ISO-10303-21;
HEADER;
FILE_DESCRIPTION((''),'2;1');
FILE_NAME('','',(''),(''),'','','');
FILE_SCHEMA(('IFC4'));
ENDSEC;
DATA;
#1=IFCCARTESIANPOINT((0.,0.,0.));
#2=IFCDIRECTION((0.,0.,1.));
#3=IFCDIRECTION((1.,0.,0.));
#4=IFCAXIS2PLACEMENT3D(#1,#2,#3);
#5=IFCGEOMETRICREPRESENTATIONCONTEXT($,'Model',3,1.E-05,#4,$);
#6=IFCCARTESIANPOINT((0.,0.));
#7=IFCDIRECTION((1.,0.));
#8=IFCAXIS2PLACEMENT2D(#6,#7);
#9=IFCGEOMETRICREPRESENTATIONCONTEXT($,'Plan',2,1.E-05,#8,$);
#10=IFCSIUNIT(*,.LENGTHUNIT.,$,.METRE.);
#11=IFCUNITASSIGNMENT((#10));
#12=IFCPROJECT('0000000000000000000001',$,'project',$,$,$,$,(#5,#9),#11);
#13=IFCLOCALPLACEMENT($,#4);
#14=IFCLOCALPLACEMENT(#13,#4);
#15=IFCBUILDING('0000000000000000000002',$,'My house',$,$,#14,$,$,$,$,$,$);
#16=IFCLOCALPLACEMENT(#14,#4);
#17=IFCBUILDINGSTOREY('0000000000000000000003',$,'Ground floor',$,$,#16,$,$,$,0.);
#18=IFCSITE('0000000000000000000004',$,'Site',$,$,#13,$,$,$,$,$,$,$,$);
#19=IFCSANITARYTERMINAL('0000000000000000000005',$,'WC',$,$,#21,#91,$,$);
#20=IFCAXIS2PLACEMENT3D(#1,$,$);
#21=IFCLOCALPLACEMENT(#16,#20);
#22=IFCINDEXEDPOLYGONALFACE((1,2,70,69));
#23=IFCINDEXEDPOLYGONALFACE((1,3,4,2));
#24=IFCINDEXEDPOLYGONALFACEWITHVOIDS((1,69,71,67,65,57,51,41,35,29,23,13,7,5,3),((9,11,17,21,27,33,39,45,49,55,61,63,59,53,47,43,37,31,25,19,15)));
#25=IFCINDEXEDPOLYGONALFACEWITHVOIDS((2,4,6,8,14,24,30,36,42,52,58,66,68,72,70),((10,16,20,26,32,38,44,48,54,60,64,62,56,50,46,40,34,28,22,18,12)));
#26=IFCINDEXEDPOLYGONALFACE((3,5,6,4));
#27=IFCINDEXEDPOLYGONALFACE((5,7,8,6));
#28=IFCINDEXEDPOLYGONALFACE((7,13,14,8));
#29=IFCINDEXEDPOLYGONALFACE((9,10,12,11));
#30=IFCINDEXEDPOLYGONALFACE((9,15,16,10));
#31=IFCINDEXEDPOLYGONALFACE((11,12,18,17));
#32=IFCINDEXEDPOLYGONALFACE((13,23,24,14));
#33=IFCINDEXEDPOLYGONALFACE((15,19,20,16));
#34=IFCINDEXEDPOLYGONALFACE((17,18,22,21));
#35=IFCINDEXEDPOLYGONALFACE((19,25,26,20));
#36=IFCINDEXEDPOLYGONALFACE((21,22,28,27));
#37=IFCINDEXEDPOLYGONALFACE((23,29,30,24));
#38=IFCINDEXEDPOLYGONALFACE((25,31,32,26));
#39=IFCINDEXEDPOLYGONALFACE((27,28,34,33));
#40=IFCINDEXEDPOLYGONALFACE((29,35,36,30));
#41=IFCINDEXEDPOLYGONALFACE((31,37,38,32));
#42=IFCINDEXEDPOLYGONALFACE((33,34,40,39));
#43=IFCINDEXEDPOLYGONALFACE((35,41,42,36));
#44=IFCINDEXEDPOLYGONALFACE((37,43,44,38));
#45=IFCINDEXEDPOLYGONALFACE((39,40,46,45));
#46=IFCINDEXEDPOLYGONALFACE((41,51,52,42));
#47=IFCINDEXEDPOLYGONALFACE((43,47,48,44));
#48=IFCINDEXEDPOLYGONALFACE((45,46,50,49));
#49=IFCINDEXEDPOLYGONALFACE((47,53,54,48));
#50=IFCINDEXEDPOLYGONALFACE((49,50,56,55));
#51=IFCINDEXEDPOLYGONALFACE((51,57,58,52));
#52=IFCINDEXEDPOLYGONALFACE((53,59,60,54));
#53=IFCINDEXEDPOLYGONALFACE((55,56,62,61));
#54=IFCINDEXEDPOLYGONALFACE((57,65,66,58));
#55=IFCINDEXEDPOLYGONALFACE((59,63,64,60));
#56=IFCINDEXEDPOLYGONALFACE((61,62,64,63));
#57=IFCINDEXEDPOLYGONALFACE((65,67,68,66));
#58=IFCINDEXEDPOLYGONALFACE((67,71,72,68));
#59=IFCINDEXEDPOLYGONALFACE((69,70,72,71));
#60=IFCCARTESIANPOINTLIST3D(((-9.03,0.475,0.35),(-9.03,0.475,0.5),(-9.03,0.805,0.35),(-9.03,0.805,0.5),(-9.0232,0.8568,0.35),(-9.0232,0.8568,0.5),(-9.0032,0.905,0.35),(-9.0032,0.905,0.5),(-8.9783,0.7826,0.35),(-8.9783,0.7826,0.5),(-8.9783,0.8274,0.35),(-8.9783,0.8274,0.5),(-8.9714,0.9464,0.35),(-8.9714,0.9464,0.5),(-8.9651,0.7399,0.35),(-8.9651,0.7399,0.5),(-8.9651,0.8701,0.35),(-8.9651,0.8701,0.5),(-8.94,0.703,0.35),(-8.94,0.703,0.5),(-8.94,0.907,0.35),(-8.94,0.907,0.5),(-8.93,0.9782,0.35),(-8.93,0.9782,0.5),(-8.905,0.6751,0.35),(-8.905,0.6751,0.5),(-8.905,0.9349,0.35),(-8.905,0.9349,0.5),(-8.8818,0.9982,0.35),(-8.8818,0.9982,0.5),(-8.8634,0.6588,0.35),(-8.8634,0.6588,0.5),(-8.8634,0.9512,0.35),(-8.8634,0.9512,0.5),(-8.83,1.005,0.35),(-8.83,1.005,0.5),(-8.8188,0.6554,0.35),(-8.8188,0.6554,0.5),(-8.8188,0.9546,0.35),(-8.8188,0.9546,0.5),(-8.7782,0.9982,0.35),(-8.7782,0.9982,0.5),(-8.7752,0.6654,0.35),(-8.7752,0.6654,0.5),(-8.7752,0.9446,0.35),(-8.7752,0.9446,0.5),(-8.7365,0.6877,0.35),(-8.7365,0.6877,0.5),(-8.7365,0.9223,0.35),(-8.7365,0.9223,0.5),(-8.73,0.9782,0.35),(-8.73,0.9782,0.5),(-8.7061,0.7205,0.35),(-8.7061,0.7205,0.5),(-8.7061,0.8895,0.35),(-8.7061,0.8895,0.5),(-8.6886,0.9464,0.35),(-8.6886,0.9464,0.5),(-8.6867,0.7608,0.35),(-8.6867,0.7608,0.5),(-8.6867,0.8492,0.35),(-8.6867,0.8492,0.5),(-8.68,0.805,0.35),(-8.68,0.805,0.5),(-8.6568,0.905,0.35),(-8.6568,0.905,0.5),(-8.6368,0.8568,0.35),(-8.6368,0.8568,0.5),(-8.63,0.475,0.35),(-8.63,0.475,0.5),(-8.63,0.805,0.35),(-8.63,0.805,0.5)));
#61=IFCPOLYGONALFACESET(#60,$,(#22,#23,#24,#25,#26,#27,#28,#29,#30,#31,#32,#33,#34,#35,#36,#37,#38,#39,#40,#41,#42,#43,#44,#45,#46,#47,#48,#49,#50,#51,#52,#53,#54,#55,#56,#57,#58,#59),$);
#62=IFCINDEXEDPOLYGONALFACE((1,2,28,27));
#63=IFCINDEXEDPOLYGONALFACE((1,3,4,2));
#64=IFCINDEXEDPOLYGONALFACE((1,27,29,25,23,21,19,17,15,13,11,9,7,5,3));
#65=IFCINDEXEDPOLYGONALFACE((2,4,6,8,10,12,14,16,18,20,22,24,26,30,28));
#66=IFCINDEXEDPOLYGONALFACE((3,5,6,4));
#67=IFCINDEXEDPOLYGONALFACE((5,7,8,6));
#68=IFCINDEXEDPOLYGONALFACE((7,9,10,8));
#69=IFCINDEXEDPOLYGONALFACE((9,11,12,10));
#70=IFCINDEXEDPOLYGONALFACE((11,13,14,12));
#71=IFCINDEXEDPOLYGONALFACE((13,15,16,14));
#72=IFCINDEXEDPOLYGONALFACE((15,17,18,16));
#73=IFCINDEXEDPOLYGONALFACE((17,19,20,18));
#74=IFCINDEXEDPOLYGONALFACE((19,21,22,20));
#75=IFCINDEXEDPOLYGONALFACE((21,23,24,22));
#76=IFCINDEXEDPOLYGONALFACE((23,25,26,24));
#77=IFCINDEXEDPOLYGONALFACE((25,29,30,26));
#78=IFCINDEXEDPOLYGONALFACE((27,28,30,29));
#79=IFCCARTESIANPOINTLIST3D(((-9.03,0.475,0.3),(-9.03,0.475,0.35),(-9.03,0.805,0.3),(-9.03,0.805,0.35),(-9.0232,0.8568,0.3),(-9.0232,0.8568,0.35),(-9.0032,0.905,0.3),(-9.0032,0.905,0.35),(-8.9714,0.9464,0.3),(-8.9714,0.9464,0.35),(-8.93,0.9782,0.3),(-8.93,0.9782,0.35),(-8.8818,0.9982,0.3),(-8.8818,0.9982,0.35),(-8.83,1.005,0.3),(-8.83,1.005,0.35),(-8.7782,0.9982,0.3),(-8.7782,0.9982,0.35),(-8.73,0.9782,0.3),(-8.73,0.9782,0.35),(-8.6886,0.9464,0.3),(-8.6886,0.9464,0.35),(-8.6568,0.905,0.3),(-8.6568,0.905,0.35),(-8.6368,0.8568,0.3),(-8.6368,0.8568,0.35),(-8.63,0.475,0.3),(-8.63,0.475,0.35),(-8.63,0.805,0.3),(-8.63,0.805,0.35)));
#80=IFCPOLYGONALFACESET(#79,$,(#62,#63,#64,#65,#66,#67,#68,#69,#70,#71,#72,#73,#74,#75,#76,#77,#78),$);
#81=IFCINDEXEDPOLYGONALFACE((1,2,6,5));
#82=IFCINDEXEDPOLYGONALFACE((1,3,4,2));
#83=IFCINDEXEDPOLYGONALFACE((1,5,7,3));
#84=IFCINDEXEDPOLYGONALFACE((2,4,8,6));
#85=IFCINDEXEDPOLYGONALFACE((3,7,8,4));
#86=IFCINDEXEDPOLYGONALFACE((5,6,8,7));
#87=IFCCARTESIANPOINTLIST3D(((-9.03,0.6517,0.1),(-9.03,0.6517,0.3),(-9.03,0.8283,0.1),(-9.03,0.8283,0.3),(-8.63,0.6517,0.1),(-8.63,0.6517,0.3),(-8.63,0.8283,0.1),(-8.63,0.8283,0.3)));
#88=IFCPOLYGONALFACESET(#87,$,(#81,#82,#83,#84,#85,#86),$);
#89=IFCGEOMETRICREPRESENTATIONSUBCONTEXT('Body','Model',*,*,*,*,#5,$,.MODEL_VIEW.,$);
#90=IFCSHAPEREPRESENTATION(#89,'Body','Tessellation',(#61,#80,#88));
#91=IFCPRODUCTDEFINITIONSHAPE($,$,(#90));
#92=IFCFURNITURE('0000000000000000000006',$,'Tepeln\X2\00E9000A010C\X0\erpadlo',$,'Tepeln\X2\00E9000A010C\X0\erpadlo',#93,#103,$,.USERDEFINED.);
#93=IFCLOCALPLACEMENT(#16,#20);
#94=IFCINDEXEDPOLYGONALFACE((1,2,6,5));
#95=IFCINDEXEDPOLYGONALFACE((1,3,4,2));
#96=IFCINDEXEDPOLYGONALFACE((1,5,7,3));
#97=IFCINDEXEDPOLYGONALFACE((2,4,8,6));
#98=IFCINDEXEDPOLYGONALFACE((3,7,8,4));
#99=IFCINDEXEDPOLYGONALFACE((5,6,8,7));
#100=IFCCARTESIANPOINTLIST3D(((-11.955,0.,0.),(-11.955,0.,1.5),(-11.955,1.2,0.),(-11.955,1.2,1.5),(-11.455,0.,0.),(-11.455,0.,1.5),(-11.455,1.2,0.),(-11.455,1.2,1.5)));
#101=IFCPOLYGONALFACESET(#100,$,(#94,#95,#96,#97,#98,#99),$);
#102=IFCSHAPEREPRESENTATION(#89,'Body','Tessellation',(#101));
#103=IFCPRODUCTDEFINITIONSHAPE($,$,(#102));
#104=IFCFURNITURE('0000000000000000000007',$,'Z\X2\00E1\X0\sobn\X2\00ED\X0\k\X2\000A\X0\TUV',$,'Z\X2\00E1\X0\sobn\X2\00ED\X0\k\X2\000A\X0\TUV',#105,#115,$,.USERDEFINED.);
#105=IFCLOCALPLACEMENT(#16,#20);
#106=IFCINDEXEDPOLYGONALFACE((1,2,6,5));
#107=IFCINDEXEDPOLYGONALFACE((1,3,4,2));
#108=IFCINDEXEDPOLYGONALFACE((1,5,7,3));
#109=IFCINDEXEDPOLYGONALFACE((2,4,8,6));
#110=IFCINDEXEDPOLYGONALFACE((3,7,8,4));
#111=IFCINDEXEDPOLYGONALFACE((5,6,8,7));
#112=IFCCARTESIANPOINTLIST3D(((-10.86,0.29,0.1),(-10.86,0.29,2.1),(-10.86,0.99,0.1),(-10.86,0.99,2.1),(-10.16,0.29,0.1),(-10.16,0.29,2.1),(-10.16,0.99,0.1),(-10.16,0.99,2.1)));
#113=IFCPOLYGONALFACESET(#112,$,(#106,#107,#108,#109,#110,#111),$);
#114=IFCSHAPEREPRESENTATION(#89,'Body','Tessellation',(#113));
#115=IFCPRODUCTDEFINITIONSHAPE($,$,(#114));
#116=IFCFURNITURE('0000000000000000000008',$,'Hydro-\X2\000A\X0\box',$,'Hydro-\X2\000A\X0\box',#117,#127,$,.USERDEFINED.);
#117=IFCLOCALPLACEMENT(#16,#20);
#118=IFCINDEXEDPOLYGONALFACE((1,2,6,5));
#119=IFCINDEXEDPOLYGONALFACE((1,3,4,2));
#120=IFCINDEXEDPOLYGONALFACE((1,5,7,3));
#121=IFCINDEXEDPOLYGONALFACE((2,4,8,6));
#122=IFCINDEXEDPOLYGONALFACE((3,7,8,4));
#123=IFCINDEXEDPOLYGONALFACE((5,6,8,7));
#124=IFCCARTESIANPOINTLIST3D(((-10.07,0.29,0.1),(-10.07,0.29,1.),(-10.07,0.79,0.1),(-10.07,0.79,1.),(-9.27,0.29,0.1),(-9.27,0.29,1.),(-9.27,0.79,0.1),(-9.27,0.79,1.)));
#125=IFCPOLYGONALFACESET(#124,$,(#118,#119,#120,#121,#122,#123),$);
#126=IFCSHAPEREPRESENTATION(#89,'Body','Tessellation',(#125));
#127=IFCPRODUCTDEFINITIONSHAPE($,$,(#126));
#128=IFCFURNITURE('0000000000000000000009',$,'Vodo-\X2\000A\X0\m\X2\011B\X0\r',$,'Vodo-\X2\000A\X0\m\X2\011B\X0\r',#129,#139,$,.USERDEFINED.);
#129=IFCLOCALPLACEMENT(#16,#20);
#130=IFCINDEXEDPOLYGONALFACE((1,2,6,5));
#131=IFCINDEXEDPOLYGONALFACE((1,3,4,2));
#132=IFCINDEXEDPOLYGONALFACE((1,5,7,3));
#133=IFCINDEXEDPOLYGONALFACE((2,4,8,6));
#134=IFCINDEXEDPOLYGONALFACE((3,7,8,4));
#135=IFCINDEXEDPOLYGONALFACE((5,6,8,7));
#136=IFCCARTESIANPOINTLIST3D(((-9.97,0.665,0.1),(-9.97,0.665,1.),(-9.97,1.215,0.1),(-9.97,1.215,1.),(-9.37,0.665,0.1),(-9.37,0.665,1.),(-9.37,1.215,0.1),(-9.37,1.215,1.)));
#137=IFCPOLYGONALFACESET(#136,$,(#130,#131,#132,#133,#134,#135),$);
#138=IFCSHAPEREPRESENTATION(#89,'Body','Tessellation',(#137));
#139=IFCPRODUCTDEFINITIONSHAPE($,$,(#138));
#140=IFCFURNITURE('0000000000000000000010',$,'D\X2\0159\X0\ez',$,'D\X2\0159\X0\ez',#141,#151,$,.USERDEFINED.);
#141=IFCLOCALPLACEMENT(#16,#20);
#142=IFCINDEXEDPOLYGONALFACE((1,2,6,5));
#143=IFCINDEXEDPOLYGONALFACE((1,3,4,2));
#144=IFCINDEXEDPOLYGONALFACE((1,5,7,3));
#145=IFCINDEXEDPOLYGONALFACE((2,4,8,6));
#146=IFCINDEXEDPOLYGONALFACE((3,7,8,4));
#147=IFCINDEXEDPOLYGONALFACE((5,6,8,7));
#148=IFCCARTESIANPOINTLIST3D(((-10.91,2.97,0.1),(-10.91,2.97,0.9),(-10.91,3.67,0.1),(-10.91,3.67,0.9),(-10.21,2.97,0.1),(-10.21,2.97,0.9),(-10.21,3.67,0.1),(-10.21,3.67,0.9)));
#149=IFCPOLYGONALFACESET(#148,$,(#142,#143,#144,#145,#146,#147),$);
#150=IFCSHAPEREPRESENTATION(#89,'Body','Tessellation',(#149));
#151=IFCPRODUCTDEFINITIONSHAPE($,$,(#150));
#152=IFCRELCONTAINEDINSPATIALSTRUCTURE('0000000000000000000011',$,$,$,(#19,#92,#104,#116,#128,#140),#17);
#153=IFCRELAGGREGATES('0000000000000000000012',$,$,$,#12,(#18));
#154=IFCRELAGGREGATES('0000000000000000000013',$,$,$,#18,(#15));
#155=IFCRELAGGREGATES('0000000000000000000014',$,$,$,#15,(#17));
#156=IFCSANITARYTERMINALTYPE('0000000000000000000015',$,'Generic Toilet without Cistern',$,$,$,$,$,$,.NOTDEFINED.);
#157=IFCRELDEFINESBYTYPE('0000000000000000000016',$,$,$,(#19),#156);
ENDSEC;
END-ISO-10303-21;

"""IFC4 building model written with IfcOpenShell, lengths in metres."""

from ifc_helpers import new_model, entity, si_unit, frame, frame_2d, origin_with_axes, origin_2d_with_axis, place, context, subcontext, project, spatial, line, arc, indexed_curve, circle_curve, outline, extrude, shape, source, transform, mapped, type_object, type_shapes, element, save


model = new_model("IFC4")

# Units and contexts
model_context = context("Model", 3, precision=1e-05, world=origin_with_axes())
plan_context = context("Plan", 2, precision=1e-05, world=origin_2d_with_axis())
body_context_1 = subcontext(model_context, "Body", "Model", "MODEL_VIEW")
body_context_2 = subcontext(plan_context, "Body", "Plan", "PLAN_VIEW")
ifc_project = project(units=[si_unit("LENGTHUNIT", "METRE")], contexts=[model_context, plan_context])

# Site, building, storey
site_placement = place(None, origin_with_axes())
site = spatial("IfcSite", under=ifc_project, at=site_placement, Name="Site")
building_placement = place(site_placement, origin_with_axes())
building = spatial("IfcBuilding", under=site, at=building_placement, Name="My house")
storey_placement = place(building_placement, origin_with_axes())
storey = spatial("IfcBuildingStorey", under=building, at=storey_placement, Name="Ground floor", Elevation=0.0)

# Sanitary terminal
sanitary_terminal_type_1 = type_object("IfcSanitaryTerminalType", Name="Generic Toilet without Cistern", PredefinedType="NOTDEFINED")
shared_shape_1 = source(origin_with_axes(), body_context_1, "Body", "SweptSolid", [
    extrude(outline(indexed_curve([(-0.2, 0.0), (0.2, 0.0), (0.2, -0.33), (0.1414, -0.4714), (0.0, -0.53), (-0.1414, -0.4714), (-0.2, -0.33)], segments=[line(1, 2), line(2, 3), arc(3, 4, 5), arc(5, 6, 7), line(7, 1)]), holes=[circle_curve(frame_2d((0.0, -0.33)), 0.15)]), frame((0.0, 0.0, 0.25), z_axis=(0.0, 0.0, 1.0), x_axis=(1.0, 0.0, 0.0)), (0.0, 0.0, 1.0), 0.15),
    extrude(outline(indexed_curve([(-0.2, 0.0), (0.2, 0.0), (0.2, -0.33), (0.1414, -0.4714), (0.0, -0.53), (-0.1414, -0.4714), (-0.2, -0.33)], segments=[line(1, 2), line(2, 3), arc(3, 4, 5), arc(5, 6, 7), line(7, 1)])), frame((0.0, 0.0, 0.2), z_axis=(0.0, 0.0, 1.0), x_axis=(1.0, 0.0, 0.0)), (0.0, 0.0, 1.0), 0.05),
    extrude(outline(indexed_curve([(-0.2, -0.1767), (0.2, -0.1767), (0.2, -0.3533), (-0.2, -0.3533)], segments=[line(1, 2, 3, 4, 1)])), origin_with_axes(), (0.0, 0.0, 1.0), 0.2),
])
shared_shape_2 = source(origin_with_axes(), body_context_1, "Body", "MappedRepresentation", [
    mapped(shared_shape_1, transform((0.0, 0.0, 0.0), x_axis=(1.0, 0.0, 0.0), y_axis=(0.0, 1.0, 0.0), z_axis=(0.0, 0.0, 1.0), scale=1.0)),
])
shared_shape_3 = source(origin_with_axes(), body_context_2, "Body", "Curve2D", [
    entity("IfcIndexedPolyCurve", entity("IfcCartesianPointList2D", [[-0.12, 0.0], [0.12, 0.0]])),
    entity("IfcIndexedPolyCurve", entity("IfcCartesianPointList2D", [[0.12, 0.0], [0.2, -0.159]])),
    entity("IfcTrimmedCurve", entity("IfcEllipse", entity("IfcAxis2Placement2D", entity("IfcCartesianPoint", [0.0, -0.159]), entity("IfcDirection", [1.0, 0.0])), 0.2, 0.371), [entity("IfcCartesianPoint", [-0.2, -0.159])], [entity("IfcCartesianPoint", [0.2, -0.159])], True, "CARTESIAN"),
    entity("IfcIndexedPolyCurve", entity("IfcCartesianPointList2D", [[-0.12, 0.0], [-0.2, -0.159]])),
    entity("IfcEllipse", entity("IfcAxis2Placement2D", entity("IfcCartesianPoint", [0.0, -0.2968]), entity("IfcDirection", [1.0, 0.0])), 0.15, 0.1855),
    entity("IfcIndexedPolyCurve", entity("IfcCartesianPointList2D", [[-0.025, -0.2968], [-0.025, -0.2703], [0.025, -0.2703], [0.025, -0.2968]])),
    entity("IfcTrimmedCurve", entity("IfcEllipse", entity("IfcAxis2Placement2D", entity("IfcCartesianPoint", [0.0, -0.2968]), entity("IfcDirection", [1.0, 0.0])), 0.025, 0.0265), [entity("IfcCartesianPoint", [-0.025, -0.2968])], [entity("IfcCartesianPoint", [0.025, -0.2968])], True, "CARTESIAN"),
])
type_shapes(sanitary_terminal_type_1, [shared_shape_1, shared_shape_3])
shared_shape_4 = source(origin_with_axes(), body_context_2, "Body", "MappedRepresentation", [
    mapped(shared_shape_3, transform((0.0, 0.0, 0.0), x_axis=(1.0, 0.0, 0.0), y_axis=(0.0, 1.0, 0.0), z_axis=(0.0, 0.0, 1.0), scale=1.0)),
])
sanitary_terminal_1_placement = place(storey_placement, frame((-8.83, 0.475, 0.1), z_axis=(0.0, 0.0, 1.0), x_axis=(-1.0, 0.0, 0.0)))
element("IfcSanitaryTerminal", 1, at=sanitary_terminal_1_placement, inside=storey, type_object=sanitary_terminal_type_1, Name="WC", shapes=[
    shape(body_context_1, "Body", "MappedRepresentation", [mapped(shared_shape_2, transform((0.0, 0.0, 0.0), x_axis=(-1.0, 0.0, 0.0), y_axis=(0.0, 1.0, 0.0), z_axis=(0.0, 0.0, 1.0), scale=1.0))]),
    shape(body_context_2, "Body", "MappedRepresentation", [mapped(shared_shape_4, transform((0.0, 0.0, 0.0), x_axis=(-1.0, 0.0, 0.0), y_axis=(0.0, 1.0, 0.0), z_axis=(0.0, 0.0, 1.0), scale=1.0))]),
])

# Furniture
shared_shape_5 = source(origin_with_axes(), body_context_1, "Body", "SweptSolid", [
    extrude(outline(indexed_curve([(-0.6, -0.25), (0.6, -0.25), (0.6, 0.25), (-0.6, 0.25)])), None, (0.0, 0.0, 1.0), 1.5),
])
shared_shape_6 = source(origin_with_axes(), body_context_2, "Body", "Curve2D", [
    entity("IfcIndexedPolyCurve", entity("IfcCartesianPointList2D", [[-0.6, -0.25], [0.6, -0.25], [0.6, 0.25], [-0.6, 0.25], [-0.6, -0.25]]), None, False),
])
furniture_1_placement = place(storey_placement, frame((-11.705, 0.6, 0.0), z_axis=(0.0, 0.0, 1.0), x_axis=(0.0, 1.0, 0.0)))
element("IfcFurniture", 2, at=furniture_1_placement, inside=storey, Name="Tepelné\nČerpadlo", ObjectType="Tepelné\nČerpadlo", PredefinedType="USERDEFINED", shapes=[
    shape(body_context_1, "Body", "MappedRepresentation", [mapped(shared_shape_5, transform((0.0, 0.0, 0.0), x_axis=(-1.0, 0.0, 0.0), y_axis=(0.0, 1.0, 0.0), z_axis=(0.0, 0.0, 1.0), scale=1.0))]),
    shape(body_context_2, "Body", "MappedRepresentation", [mapped(shared_shape_6, transform((0.0, 0.0, 0.0), x_axis=(-1.0, 0.0, 0.0), y_axis=(0.0, 1.0, 0.0), z_axis=(0.0, 0.0, 1.0), scale=1.0))]),
])
shared_shape_7 = source(origin_with_axes(), body_context_1, "Body", "SweptSolid", [
    extrude(outline(indexed_curve([(-0.35, -0.35), (0.35, -0.35), (0.35, 0.35), (-0.35, 0.35)])), None, (0.0, 0.0, 1.0), 2.0),
])
shared_shape_8 = source(origin_with_axes(), body_context_2, "Body", "Curve2D", [
    entity("IfcIndexedPolyCurve", entity("IfcCartesianPointList2D", [[-0.35, -0.35], [0.35, -0.35], [0.35, 0.35], [-0.35, 0.35], [-0.35, -0.35]]), None, False),
])
furniture_2_placement = place(storey_placement, frame((-10.51, 0.64, 0.1), z_axis=(0.0, 0.0, 1.0), x_axis=(1.0, 0.0, 0.0)))
element("IfcFurniture", 3, at=furniture_2_placement, inside=storey, Name="Zásobník\nTUV", ObjectType="Zásobník\nTUV", PredefinedType="USERDEFINED", shapes=[
    shape(body_context_1, "Body", "MappedRepresentation", [mapped(shared_shape_7, transform((0.0, 0.0, 0.0), x_axis=(-1.0, 0.0, 0.0), y_axis=(0.0, 1.0, 0.0), z_axis=(0.0, 0.0, 1.0), scale=1.0))]),
    shape(body_context_2, "Body", "MappedRepresentation", [mapped(shared_shape_8, transform((0.0, 0.0, 0.0), x_axis=(-1.0, 0.0, 0.0), y_axis=(0.0, 1.0, 0.0), z_axis=(0.0, 0.0, 1.0), scale=1.0))]),
])
shared_shape_9 = source(origin_with_axes(), body_context_1, "Body", "SweptSolid", [
    extrude(outline(indexed_curve([(-0.4, -0.25), (0.4, -0.25), (0.4, 0.25), (-0.4, 0.25)])), None, (0.0, 0.0, 1.0), 0.9),
])
shared_shape_10 = source(origin_with_axes(), body_context_2, "Body", "Curve2D", [
    entity("IfcIndexedPolyCurve", entity("IfcCartesianPointList2D", [[-0.4, -0.25], [0.4, -0.25], [0.4, 0.25], [-0.4, 0.25], [-0.4, -0.25]]), None, False),
])
furniture_3_placement = place(storey_placement, frame((-9.67, 0.54, 0.1), z_axis=(0.0, 0.0, 1.0), x_axis=(1.0, 0.0, 0.0)))
element("IfcFurniture", 4, at=furniture_3_placement, inside=storey, Name="Hydro-\nbox", ObjectType="Hydro-\nbox", PredefinedType="USERDEFINED", shapes=[
    shape(body_context_1, "Body", "MappedRepresentation", [mapped(shared_shape_9, transform((0.0, 0.0, 0.0), x_axis=(-1.0, 0.0, 0.0), y_axis=(0.0, 1.0, 0.0), z_axis=(0.0, 0.0, 1.0), scale=1.0))]),
    shape(body_context_2, "Body", "MappedRepresentation", [mapped(shared_shape_10, transform((0.0, 0.0, 0.0), x_axis=(-1.0, 0.0, 0.0), y_axis=(0.0, 1.0, 0.0), z_axis=(0.0, 0.0, 1.0), scale=1.0))]),
])
shared_shape_11 = source(origin_with_axes(), body_context_1, "Body", "SweptSolid", [
    extrude(outline(indexed_curve([(-0.3, -0.275), (0.3, -0.275), (0.3, 0.275), (-0.3, 0.275)])), None, (0.0, 0.0, 1.0), 0.9),
])
shared_shape_12 = source(origin_with_axes(), body_context_2, "Body", "Curve2D", [
    entity("IfcIndexedPolyCurve", entity("IfcCartesianPointList2D", [[-0.3, -0.275], [0.3, -0.275], [0.3, 0.275], [-0.3, 0.275], [-0.3, -0.275]]), None, False),
])
furniture_4_placement = place(storey_placement, frame((-9.67, 0.94, 0.1), z_axis=(0.0, 0.0, 1.0), x_axis=(1.0, 0.0, 0.0)))
element("IfcFurniture", 5, at=furniture_4_placement, inside=storey, Name="Vodo-\nměr", ObjectType="Vodo-\nměr", PredefinedType="USERDEFINED", shapes=[
    shape(body_context_1, "Body", "MappedRepresentation", [mapped(shared_shape_11, transform((0.0, 0.0, 0.0), x_axis=(-1.0, 0.0, 0.0), y_axis=(0.0, 1.0, 0.0), z_axis=(0.0, 0.0, 1.0), scale=1.0))]),
    shape(body_context_2, "Body", "MappedRepresentation", [mapped(shared_shape_12, transform((0.0, 0.0, 0.0), x_axis=(-1.0, 0.0, 0.0), y_axis=(0.0, 1.0, 0.0), z_axis=(0.0, 0.0, 1.0), scale=1.0))]),
])
shared_shape_13 = source(origin_with_axes(), body_context_1, "Body", "SweptSolid", [
    extrude(outline(indexed_curve([(-0.35, -0.35), (0.35, -0.35), (0.35, 0.35), (-0.35, 0.35)])), None, (0.0, 0.0, 1.0), 0.8),
])
shared_shape_14 = source(origin_with_axes(), body_context_2, "Body", "Curve2D", [
    entity("IfcIndexedPolyCurve", entity("IfcCartesianPointList2D", [[-0.35, -0.35], [0.35, -0.35], [0.35, 0.35], [-0.35, 0.35], [-0.35, -0.35]]), None, False),
])
furniture_5_placement = place(storey_placement, frame((-10.56, 3.32, 0.1), z_axis=(0.0, 0.0, 1.0), x_axis=(1.0, 0.0, 0.0)))
element("IfcFurniture", 6, at=furniture_5_placement, inside=storey, Name="Dřez", ObjectType="Dřez", PredefinedType="USERDEFINED", shapes=[
    shape(body_context_1, "Body", "MappedRepresentation", [mapped(shared_shape_13, transform((0.0, 0.0, 0.0), x_axis=(-1.0, 0.0, 0.0), y_axis=(0.0, 1.0, 0.0), z_axis=(0.0, 0.0, 1.0), scale=1.0))]),
    shape(body_context_2, "Body", "MappedRepresentation", [mapped(shared_shape_14, transform((0.0, 0.0, 0.0), x_axis=(-1.0, 0.0, 0.0), y_axis=(0.0, 1.0, 0.0), z_axis=(0.0, 0.0, 1.0), scale=1.0))]),
])

save(model, "model.ifc")
